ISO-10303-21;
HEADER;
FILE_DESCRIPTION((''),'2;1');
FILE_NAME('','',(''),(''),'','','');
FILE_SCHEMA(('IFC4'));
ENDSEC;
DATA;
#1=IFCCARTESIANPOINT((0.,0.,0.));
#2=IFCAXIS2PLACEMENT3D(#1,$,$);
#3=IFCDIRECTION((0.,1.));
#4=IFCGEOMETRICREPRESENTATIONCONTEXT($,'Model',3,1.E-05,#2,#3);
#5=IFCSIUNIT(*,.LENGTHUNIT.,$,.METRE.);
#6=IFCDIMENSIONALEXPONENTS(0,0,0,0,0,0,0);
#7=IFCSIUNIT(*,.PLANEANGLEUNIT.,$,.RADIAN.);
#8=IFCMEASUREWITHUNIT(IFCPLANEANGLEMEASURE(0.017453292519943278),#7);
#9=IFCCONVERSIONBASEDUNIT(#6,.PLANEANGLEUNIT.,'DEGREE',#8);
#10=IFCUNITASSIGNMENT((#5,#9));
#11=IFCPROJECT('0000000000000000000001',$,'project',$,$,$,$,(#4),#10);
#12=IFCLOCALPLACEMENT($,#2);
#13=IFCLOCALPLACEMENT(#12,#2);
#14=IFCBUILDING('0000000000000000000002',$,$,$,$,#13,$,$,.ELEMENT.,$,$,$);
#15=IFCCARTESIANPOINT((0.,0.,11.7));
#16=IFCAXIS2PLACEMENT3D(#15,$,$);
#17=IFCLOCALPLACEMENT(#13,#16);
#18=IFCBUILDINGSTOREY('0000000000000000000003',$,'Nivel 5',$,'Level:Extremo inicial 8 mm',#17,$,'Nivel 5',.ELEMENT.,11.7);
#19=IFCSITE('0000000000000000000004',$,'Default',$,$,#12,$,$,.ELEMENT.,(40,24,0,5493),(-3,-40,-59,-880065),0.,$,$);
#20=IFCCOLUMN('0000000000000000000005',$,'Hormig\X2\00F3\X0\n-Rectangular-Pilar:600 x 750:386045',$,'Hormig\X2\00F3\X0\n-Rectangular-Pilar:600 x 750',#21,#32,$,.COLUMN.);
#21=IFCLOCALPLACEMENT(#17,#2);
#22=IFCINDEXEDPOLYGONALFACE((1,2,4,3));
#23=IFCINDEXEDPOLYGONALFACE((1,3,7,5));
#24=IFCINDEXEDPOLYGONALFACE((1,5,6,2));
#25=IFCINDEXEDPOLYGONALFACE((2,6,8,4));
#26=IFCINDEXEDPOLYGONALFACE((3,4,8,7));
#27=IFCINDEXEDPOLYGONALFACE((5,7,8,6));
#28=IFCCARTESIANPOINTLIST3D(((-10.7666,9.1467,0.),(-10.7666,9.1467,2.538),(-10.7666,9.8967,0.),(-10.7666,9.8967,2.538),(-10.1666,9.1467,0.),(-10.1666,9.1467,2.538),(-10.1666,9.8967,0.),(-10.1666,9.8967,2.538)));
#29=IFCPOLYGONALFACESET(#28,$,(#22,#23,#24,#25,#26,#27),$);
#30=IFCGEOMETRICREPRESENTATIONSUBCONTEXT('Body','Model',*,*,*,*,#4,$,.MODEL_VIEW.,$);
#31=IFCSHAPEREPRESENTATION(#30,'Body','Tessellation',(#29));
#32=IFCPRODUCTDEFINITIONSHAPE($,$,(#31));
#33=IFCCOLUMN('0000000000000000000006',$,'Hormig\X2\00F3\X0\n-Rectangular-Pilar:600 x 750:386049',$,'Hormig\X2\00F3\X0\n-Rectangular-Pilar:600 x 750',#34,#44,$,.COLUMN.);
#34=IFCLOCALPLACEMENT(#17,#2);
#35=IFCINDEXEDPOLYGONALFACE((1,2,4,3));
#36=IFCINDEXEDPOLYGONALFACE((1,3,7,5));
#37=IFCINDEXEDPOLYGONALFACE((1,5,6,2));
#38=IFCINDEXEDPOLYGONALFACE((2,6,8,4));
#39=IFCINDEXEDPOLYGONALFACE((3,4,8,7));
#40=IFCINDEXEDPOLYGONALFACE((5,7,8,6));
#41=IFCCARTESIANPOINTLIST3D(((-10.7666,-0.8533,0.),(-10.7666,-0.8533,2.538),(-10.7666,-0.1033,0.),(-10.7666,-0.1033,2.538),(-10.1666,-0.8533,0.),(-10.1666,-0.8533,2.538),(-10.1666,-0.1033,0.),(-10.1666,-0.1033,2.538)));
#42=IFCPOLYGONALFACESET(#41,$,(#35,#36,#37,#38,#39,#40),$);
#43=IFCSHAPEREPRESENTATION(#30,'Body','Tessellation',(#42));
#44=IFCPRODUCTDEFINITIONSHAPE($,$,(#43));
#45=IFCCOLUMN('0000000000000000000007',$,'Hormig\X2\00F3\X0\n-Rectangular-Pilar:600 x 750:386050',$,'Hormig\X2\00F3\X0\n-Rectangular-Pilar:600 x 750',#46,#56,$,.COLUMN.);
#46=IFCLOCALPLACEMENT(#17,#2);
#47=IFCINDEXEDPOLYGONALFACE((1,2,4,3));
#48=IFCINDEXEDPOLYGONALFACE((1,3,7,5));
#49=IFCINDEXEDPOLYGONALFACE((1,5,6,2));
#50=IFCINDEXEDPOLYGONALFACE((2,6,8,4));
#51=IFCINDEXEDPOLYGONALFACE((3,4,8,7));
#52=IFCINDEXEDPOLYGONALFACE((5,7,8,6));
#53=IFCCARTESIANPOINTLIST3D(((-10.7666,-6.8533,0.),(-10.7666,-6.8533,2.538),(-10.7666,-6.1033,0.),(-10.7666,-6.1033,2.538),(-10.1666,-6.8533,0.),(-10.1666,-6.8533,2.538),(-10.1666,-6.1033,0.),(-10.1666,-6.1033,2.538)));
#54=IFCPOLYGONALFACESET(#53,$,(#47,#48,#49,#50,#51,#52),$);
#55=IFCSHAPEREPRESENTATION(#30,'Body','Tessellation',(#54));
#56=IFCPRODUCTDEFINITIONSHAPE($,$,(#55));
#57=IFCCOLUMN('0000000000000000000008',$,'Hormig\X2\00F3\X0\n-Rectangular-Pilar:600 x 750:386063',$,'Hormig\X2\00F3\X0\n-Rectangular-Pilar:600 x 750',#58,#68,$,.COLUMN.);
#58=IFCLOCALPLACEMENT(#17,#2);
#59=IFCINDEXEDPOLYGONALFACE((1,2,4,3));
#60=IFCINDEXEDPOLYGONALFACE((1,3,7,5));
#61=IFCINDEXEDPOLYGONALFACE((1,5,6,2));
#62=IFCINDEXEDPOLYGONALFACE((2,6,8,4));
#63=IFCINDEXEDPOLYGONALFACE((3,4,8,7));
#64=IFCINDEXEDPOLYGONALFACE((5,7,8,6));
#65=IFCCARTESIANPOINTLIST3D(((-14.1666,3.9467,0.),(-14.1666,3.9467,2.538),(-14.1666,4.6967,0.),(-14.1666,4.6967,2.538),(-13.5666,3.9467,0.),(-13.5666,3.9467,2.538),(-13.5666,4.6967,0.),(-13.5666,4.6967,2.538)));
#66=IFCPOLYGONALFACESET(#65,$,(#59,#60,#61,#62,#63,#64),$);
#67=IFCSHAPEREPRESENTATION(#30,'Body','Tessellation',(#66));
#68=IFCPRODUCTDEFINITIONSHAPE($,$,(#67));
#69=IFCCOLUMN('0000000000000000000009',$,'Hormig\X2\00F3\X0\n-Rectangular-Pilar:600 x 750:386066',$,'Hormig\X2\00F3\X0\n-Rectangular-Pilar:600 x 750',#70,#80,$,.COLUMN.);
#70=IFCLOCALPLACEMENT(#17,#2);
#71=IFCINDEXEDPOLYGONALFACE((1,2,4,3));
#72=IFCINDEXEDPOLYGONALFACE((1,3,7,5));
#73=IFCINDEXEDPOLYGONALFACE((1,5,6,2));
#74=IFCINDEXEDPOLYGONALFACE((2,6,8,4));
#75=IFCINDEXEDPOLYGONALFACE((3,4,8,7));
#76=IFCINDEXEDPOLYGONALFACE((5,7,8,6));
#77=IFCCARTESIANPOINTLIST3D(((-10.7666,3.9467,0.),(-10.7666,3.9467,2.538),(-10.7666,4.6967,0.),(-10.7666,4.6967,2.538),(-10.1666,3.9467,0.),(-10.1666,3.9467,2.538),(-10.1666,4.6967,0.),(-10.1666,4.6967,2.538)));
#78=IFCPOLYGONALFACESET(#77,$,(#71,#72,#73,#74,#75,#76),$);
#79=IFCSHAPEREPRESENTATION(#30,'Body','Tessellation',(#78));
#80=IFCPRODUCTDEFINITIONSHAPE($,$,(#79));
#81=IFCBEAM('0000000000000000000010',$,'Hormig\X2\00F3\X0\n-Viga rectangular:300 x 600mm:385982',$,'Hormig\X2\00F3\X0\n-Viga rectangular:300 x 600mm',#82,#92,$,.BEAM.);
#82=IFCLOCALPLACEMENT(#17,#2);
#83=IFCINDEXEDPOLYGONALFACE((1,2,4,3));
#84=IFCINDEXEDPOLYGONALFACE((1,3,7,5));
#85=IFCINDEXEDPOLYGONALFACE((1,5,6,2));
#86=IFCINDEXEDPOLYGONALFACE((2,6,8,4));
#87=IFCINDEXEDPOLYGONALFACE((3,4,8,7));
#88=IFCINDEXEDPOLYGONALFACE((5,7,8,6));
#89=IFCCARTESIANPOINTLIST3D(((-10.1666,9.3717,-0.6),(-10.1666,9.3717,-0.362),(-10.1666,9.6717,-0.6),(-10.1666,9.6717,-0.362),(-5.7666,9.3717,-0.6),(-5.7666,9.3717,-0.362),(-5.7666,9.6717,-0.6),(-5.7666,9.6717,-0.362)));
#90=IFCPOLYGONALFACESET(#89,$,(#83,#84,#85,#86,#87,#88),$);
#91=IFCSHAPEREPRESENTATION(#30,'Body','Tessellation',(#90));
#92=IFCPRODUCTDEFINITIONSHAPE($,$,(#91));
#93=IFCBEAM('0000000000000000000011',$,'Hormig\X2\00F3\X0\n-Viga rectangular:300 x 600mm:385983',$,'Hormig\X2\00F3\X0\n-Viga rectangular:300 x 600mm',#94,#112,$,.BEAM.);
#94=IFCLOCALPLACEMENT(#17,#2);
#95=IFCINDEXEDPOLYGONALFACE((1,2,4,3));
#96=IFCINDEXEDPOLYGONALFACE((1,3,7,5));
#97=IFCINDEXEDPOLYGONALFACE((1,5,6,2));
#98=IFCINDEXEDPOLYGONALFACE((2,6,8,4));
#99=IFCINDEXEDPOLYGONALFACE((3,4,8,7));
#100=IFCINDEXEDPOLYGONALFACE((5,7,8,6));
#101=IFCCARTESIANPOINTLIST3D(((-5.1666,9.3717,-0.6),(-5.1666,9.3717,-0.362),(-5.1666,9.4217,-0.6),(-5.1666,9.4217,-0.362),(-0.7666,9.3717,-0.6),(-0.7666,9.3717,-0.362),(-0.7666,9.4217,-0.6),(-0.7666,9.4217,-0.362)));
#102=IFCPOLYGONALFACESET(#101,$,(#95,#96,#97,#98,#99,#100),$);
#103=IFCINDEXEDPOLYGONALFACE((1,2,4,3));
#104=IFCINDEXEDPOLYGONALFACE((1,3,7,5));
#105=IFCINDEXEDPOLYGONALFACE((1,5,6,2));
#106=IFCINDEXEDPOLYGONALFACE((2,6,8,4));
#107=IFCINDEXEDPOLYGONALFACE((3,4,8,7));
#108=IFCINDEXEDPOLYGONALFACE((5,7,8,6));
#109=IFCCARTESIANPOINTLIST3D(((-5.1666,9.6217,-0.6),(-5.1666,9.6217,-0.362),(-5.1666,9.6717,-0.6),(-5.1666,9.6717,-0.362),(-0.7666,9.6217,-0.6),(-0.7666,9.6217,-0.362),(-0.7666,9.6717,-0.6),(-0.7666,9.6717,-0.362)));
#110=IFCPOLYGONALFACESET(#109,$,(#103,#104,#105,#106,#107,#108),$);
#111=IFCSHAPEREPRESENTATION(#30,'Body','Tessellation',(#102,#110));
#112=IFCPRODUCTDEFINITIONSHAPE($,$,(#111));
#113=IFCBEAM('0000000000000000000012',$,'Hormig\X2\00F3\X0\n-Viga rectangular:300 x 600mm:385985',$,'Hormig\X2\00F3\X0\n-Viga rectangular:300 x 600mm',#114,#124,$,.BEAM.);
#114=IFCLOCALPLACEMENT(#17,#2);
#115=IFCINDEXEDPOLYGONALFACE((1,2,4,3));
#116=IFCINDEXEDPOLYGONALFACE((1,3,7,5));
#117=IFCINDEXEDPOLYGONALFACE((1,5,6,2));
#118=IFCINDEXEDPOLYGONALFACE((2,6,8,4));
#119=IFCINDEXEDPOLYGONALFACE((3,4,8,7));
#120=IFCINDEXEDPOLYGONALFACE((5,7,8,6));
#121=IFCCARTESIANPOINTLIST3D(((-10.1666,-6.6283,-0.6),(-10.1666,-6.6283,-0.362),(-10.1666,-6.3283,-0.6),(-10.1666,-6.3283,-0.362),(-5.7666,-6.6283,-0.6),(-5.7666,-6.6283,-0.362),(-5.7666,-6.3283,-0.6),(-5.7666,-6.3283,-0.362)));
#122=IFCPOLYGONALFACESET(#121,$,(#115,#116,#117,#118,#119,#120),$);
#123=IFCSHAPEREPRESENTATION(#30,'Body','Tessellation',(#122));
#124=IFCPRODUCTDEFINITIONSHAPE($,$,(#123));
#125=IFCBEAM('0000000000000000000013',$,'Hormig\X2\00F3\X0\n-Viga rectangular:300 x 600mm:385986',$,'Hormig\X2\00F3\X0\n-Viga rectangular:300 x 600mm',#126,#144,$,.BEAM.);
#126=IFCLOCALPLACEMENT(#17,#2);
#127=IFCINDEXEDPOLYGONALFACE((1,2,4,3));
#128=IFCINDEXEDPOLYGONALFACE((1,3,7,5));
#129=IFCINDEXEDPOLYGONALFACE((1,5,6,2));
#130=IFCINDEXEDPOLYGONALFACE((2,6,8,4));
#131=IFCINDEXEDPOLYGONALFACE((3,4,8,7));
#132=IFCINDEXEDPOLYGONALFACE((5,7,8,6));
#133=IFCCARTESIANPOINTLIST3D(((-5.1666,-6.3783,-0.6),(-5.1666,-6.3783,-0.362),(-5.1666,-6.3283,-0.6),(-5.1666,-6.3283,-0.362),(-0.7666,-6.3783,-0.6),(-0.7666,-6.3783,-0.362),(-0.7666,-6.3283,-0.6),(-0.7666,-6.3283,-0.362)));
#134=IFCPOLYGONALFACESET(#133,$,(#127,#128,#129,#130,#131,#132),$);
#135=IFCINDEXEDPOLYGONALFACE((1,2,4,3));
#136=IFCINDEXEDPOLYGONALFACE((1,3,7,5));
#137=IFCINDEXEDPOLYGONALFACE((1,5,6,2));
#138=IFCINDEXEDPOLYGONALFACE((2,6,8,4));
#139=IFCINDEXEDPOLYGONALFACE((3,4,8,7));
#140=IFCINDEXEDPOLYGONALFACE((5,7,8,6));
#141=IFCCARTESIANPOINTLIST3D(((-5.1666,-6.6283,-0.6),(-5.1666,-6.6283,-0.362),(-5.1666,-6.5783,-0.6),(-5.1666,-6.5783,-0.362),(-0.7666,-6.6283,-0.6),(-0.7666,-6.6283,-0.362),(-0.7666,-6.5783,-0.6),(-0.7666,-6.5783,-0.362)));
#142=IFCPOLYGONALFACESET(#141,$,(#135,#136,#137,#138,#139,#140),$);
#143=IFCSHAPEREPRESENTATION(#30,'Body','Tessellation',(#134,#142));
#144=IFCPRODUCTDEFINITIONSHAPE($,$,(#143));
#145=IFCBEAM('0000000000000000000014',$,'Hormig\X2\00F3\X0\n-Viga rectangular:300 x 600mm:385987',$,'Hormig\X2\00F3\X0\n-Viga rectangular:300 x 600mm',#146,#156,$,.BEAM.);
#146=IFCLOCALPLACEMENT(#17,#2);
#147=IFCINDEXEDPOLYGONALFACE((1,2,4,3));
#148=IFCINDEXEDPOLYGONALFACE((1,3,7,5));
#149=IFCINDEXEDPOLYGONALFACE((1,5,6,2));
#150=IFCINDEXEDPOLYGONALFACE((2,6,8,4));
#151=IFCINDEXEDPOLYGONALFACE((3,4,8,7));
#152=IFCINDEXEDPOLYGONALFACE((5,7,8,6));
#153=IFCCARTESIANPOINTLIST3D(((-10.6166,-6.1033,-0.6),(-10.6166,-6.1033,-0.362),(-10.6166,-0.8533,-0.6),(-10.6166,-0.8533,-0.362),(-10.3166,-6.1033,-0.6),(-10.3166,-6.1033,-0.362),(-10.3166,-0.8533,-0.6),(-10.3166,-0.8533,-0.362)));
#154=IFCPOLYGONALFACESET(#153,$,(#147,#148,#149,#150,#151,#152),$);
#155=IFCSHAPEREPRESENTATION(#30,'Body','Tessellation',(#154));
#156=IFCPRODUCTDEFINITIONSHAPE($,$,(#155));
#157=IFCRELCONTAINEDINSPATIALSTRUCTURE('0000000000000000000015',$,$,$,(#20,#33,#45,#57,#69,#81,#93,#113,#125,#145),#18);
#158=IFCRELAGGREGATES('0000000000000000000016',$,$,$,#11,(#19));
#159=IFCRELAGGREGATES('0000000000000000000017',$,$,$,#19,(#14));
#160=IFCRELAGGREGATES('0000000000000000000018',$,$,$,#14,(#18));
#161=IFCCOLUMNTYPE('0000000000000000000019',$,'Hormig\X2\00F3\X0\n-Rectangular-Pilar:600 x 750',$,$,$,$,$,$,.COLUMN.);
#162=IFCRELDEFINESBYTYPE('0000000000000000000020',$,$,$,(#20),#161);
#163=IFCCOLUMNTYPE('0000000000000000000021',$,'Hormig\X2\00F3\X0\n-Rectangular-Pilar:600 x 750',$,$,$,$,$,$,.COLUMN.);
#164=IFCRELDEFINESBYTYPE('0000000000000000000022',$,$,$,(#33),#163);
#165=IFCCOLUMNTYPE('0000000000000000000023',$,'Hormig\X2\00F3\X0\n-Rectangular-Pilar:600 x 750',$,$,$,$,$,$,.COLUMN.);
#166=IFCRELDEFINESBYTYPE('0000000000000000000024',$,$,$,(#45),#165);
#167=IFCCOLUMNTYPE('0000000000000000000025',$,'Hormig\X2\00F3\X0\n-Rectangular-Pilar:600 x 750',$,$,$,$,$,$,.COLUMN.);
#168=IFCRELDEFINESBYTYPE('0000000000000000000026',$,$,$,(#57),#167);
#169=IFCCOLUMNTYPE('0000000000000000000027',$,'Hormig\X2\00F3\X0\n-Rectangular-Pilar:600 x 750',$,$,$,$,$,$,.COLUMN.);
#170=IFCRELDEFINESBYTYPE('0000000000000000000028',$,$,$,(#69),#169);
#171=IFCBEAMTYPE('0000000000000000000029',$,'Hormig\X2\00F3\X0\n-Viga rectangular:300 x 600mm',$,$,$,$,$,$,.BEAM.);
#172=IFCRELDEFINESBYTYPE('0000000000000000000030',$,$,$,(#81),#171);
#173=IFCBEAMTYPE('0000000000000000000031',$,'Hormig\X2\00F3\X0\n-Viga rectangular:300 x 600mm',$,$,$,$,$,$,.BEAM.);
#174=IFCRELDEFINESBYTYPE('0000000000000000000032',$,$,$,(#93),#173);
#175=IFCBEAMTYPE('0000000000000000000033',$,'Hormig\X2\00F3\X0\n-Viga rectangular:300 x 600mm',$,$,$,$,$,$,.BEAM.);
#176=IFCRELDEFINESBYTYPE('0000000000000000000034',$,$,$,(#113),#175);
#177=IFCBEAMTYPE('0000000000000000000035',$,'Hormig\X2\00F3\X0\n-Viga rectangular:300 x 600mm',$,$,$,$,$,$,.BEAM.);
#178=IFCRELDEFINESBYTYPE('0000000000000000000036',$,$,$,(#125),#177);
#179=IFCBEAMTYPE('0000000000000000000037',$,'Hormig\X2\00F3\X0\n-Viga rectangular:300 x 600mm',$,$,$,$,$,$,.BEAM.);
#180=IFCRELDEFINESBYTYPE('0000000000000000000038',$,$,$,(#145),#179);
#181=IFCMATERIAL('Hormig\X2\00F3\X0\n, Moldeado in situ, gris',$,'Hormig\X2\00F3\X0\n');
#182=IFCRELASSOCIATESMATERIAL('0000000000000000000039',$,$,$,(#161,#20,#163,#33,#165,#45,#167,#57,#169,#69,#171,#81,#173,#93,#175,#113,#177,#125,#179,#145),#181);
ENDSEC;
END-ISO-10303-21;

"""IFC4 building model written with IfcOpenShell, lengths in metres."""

from ifc_helpers import new_model, entity, si_unit, converted_unit, direction, frame, origin, place, context, subcontext, project, spatial, indexed_curve, outline, extrude, source, transform, mapped, material, type_object, type_shapes, element, save


model = new_model("IFC4")

# Units and contexts
model_context = context("Model", 3, precision=1e-05, world=origin(), true_north=direction((0.0, 1.0)))
body_context = subcontext(model_context, "Body", "Model", "MODEL_VIEW")
ifc_project = project(units=[si_unit("LENGTHUNIT", "METRE"), converted_unit("PLANEANGLEUNIT", "DEGREE", entity("IfcPlaneAngleMeasure", 0.017453292519943278), si_unit("PLANEANGLEUNIT", "RADIAN"), dimensions=[0, 0, 0, 0, 0, 0, 0])], contexts=[model_context])

# Site, building, storey
site_placement = place(None, origin())
site = spatial("IfcSite", under=ifc_project, at=site_placement, Name="Default", CompositionType="ELEMENT", RefLatitude=(40, 24, 0, 5493), RefLongitude=(-3, -40, -59, -880065), RefElevation=0.0)
building_placement = place(site_placement, origin())
building = spatial("IfcBuilding", under=site, at=building_placement, CompositionType="ELEMENT")
storey_placement = place(building_placement, frame((0.0, 0.0, 11.7)))
storey = spatial("IfcBuildingStorey", under=building, at=storey_placement, Name="Nivel 5", ObjectType="Level:Extremo inicial 8 mm", LongName="Nivel 5", CompositionType="ELEMENT", Elevation=11.7)

# Columns
ifc_material_1 = material(Name="Hormigón, Moldeado in situ, gris", Category="Hormigón")
column_type_1 = type_object("IfcColumnType", Name="Hormigón-Rectangular-Pilar:600 x 750", PredefinedType="COLUMN", material=ifc_material_1)
shared_shape_1 = source(origin(), body_context, "Body", "SweptSolid", [
    extrude(outline(indexed_curve([(-0.3, -0.375), (0.3, -0.375), (0.3, 0.375), (-0.3, 0.375), (-0.3, -0.375)], self_intersect=False)), frame((-10.4666, 9.5217, 11.7), z_axis=(0.0, 0.0, 1.0), x_axis=(-1.0, 0.0, 0.0)), (0.0, 0.0, 1.0), 2.538),
])
type_shapes(column_type_1, [shared_shape_1])
column_1_placement = place(storey_placement, frame((0.0, 0.0, -11.7)))
element("IfcColumn", 1, at=column_1_placement, inside=storey, type_object=column_type_1, material=ifc_material_1, Name="Hormigón-Rectangular-Pilar:600 x 750:386045", ObjectType="Hormigón-Rectangular-Pilar:600 x 750", PredefinedType="COLUMN", context=body_context, shape_type="MappedRepresentation", body=[
    mapped(shared_shape_1, transform((0.0, 0.0, 0.0), scale=1.0)),
])
column_type_2 = type_object("IfcColumnType", Name="Hormigón-Rectangular-Pilar:600 x 750", PredefinedType="COLUMN", material=ifc_material_1)
shared_shape_2 = source(origin(), body_context, "Body", "SweptSolid", [
    extrude(outline(indexed_curve([(-0.3, -0.375), (0.3, -0.375), (0.3, 0.375), (-0.3, 0.375), (-0.3, -0.375)], self_intersect=False)), frame((-10.4666, -0.4783, 11.7), z_axis=(0.0, 0.0, 1.0), x_axis=(-1.0, 0.0, 0.0)), (0.0, 0.0, 1.0), 2.538),
])
type_shapes(column_type_2, [shared_shape_2])
column_2_placement = place(storey_placement, frame((0.0, 0.0, -11.7)))
element("IfcColumn", 2, at=column_2_placement, inside=storey, type_object=column_type_2, material=ifc_material_1, Name="Hormigón-Rectangular-Pilar:600 x 750:386049", ObjectType="Hormigón-Rectangular-Pilar:600 x 750", PredefinedType="COLUMN", context=body_context, shape_type="MappedRepresentation", body=[
    mapped(shared_shape_2, transform((0.0, 0.0, 0.0), scale=1.0)),
])
column_type_3 = type_object("IfcColumnType", Name="Hormigón-Rectangular-Pilar:600 x 750", PredefinedType="COLUMN", material=ifc_material_1)
shared_shape_3 = source(origin(), body_context, "Body", "SweptSolid", [
    extrude(outline(indexed_curve([(-0.3, -0.375), (0.3, -0.375), (0.3, 0.375), (-0.3, 0.375), (-0.3, -0.375)], self_intersect=False)), frame((-10.4666, -6.4783, 11.7), z_axis=(0.0, 0.0, 1.0), x_axis=(-1.0, 0.0, 0.0)), (0.0, 0.0, 1.0), 2.538),
])
type_shapes(column_type_3, [shared_shape_3])
column_3_placement = place(storey_placement, frame((0.0, 0.0, -11.7)))
element("IfcColumn", 3, at=column_3_placement, inside=storey, type_object=column_type_3, material=ifc_material_1, Name="Hormigón-Rectangular-Pilar:600 x 750:386050", ObjectType="Hormigón-Rectangular-Pilar:600 x 750", PredefinedType="COLUMN", context=body_context, shape_type="MappedRepresentation", body=[
    mapped(shared_shape_3, transform((0.0, 0.0, 0.0), scale=1.0)),
])
column_type_4 = type_object("IfcColumnType", Name="Hormigón-Rectangular-Pilar:600 x 750", PredefinedType="COLUMN", material=ifc_material_1)
shared_shape_4 = source(origin(), body_context, "Body", "SweptSolid", [
    extrude(outline(indexed_curve([(-0.3, -0.375), (0.3, -0.375), (0.3, 0.375), (-0.3, 0.375), (-0.3, -0.375)], self_intersect=False)), frame((-13.8666, 4.3217, 11.7), z_axis=(0.0, 0.0, 1.0), x_axis=(-1.0, 0.0, 0.0)), (0.0, 0.0, 1.0), 2.538),
])
type_shapes(column_type_4, [shared_shape_4])
column_4_placement = place(storey_placement, frame((0.0, 0.0, -11.7)))
element("IfcColumn", 4, at=column_4_placement, inside=storey, type_object=column_type_4, material=ifc_material_1, Name="Hormigón-Rectangular-Pilar:600 x 750:386063", ObjectType="Hormigón-Rectangular-Pilar:600 x 750", PredefinedType="COLUMN", context=body_context, shape_type="MappedRepresentation", body=[
    mapped(shared_shape_4, transform((0.0, 0.0, 0.0), scale=1.0)),
])
column_type_5 = type_object("IfcColumnType", Name="Hormigón-Rectangular-Pilar:600 x 750", PredefinedType="COLUMN", material=ifc_material_1)
shared_shape_5 = source(origin(), body_context, "Body", "SweptSolid", [
    extrude(outline(indexed_curve([(-0.3, -0.375), (0.3, -0.375), (0.3, 0.375), (-0.3, 0.375), (-0.3, -0.375)], self_intersect=False)), frame((-10.4666, 4.3217, 11.7), z_axis=(0.0, 0.0, 1.0), x_axis=(-1.0, 0.0, 0.0)), (0.0, 0.0, 1.0), 2.538),
])
type_shapes(column_type_5, [shared_shape_5])
column_5_placement = place(storey_placement, frame((0.0, 0.0, -11.7)))
element("IfcColumn", 5, at=column_5_placement, inside=storey, type_object=column_type_5, material=ifc_material_1, Name="Hormigón-Rectangular-Pilar:600 x 750:386066", ObjectType="Hormigón-Rectangular-Pilar:600 x 750", PredefinedType="COLUMN", context=body_context, shape_type="MappedRepresentation", body=[
    mapped(shared_shape_5, transform((0.0, 0.0, 0.0), scale=1.0)),
])

# Beams
beam_type_1 = type_object("IfcBeamType", Name="Hormigón-Viga rectangular:300 x 600mm", PredefinedType="BEAM", material=ifc_material_1)
shared_shape_6 = source(origin(), body_context, "Body", "SweptSolid", [
    extrude(outline(indexed_curve([(-0.119, -0.15), (0.119, -0.15), (0.119, 0.15), (-0.119, 0.15), (-0.119, -0.15)], self_intersect=False)), frame((-5.7666, 9.5217, 11.219), z_axis=(-1.0, 0.0, 0.0), x_axis=(0.0, 0.0, -1.0)), (0.0, 0.0, 1.0), 4.4),
])
type_shapes(beam_type_1, [shared_shape_6])
beam_1_placement = place(storey_placement, frame((0.0, 0.0, -11.7)))
element("IfcBeam", 6, at=beam_1_placement, inside=storey, type_object=beam_type_1, material=ifc_material_1, Name="Hormigón-Viga rectangular:300 x 600mm:385982", ObjectType="Hormigón-Viga rectangular:300 x 600mm", PredefinedType="BEAM", context=body_context, shape_type="MappedRepresentation", body=[
    mapped(shared_shape_6, transform((0.0, 0.0, 0.0), scale=1.0)),
])
beam_type_2 = type_object("IfcBeamType", Name="Hormigón-Viga rectangular:300 x 600mm", PredefinedType="BEAM", material=ifc_material_1)
shared_shape_7 = source(origin(), body_context, "Body", "SweptSolid", [
    extrude(outline(indexed_curve([(-0.119, -0.025), (0.119, -0.025), (0.119, 0.025), (-0.119, 0.025), (-0.119, -0.025)], self_intersect=False)), frame((-5.1666, 9.3967, 11.219), z_axis=(1.0, 0.0, 0.0), x_axis=(0.0, 0.0, -1.0)), (0.0, 0.0, 1.0), 4.4),
    extrude(outline(indexed_curve([(-0.119, -0.025), (0.119, -0.025), (0.119, 0.025), (-0.119, 0.025), (-0.119, -0.025)], self_intersect=False)), frame((-5.1666, 9.6467, 11.219), z_axis=(1.0, 0.0, 0.0), x_axis=(0.0, 0.0, -1.0)), (0.0, 0.0, 1.0), 4.4),
])
type_shapes(beam_type_2, [shared_shape_7])
beam_2_placement = place(storey_placement, frame((0.0, 0.0, -11.7)))
element("IfcBeam", 7, at=beam_2_placement, inside=storey, type_object=beam_type_2, material=ifc_material_1, Name="Hormigón-Viga rectangular:300 x 600mm:385983", ObjectType="Hormigón-Viga rectangular:300 x 600mm", PredefinedType="BEAM", context=body_context, shape_type="MappedRepresentation", body=[
    mapped(shared_shape_7, transform((0.0, 0.0, 0.0), scale=1.0)),
])
beam_type_3 = type_object("IfcBeamType", Name="Hormigón-Viga rectangular:300 x 600mm", PredefinedType="BEAM", material=ifc_material_1)
shared_shape_8 = source(origin(), body_context, "Body", "SweptSolid", [
    extrude(outline(indexed_curve([(-0.119, -0.15), (0.119, -0.15), (0.119, 0.15), (-0.119, 0.15), (-0.119, -0.15)], self_intersect=False)), frame((-10.1666, -6.4783, 11.219), z_axis=(1.0, 0.0, 0.0), x_axis=(0.0, 0.0, -1.0)), (0.0, 0.0, 1.0), 4.4),
])
type_shapes(beam_type_3, [shared_shape_8])
beam_3_placement = place(storey_placement, frame((0.0, 0.0, -11.7)))
element("IfcBeam", 8, at=beam_3_placement, inside=storey, type_object=beam_type_3, material=ifc_material_1, Name="Hormigón-Viga rectangular:300 x 600mm:385985", ObjectType="Hormigón-Viga rectangular:300 x 600mm", PredefinedType="BEAM", context=body_context, shape_type="MappedRepresentation", body=[
    mapped(shared_shape_8, transform((0.0, 0.0, 0.0), scale=1.0)),
])
beam_type_4 = type_object("IfcBeamType", Name="Hormigón-Viga rectangular:300 x 600mm", PredefinedType="BEAM", material=ifc_material_1)
shared_shape_9 = source(origin(), body_context, "Body", "SweptSolid", [
    extrude(outline(indexed_curve([(-0.119, -0.025), (0.119, -0.025), (0.119, 0.025), (-0.119, 0.025), (-0.119, -0.025)], self_intersect=False)), frame((-0.7666, -6.3533, 11.219), z_axis=(-1.0, 0.0, 0.0), x_axis=(0.0, 0.0, -1.0)), (0.0, 0.0, 1.0), 4.4),
    extrude(outline(indexed_curve([(-0.119, -0.025), (0.119, -0.025), (0.119, 0.025), (-0.119, 0.025), (-0.119, -0.025)], self_intersect=False)), frame((-0.7666, -6.6033, 11.219), z_axis=(-1.0, 0.0, 0.0), x_axis=(0.0, 0.0, -1.0)), (0.0, 0.0, 1.0), 4.4),
])
type_shapes(beam_type_4, [shared_shape_9])
beam_4_placement = place(storey_placement, frame((0.0, 0.0, -11.7)))
element("IfcBeam", 9, at=beam_4_placement, inside=storey, type_object=beam_type_4, material=ifc_material_1, Name="Hormigón-Viga rectangular:300 x 600mm:385986", ObjectType="Hormigón-Viga rectangular:300 x 600mm", PredefinedType="BEAM", context=body_context, shape_type="MappedRepresentation", body=[
    mapped(shared_shape_9, transform((0.0, 0.0, 0.0), scale=1.0)),
])
beam_type_5 = type_object("IfcBeamType", Name="Hormigón-Viga rectangular:300 x 600mm", PredefinedType="BEAM", material=ifc_material_1)
shared_shape_10 = source(origin(), body_context, "Body", "SweptSolid", [
    extrude(outline(indexed_curve([(-0.15, -0.119), (0.15, -0.119), (0.15, 0.119), (-0.15, 0.119), (-0.15, -0.119)], self_intersect=False)), frame((-10.4666, -6.1033, 11.219), z_axis=(0.0, 1.0, 0.0), x_axis=(-1.0, 0.0, 0.0)), (0.0, 0.0, 1.0), 5.25),
])
type_shapes(beam_type_5, [shared_shape_10])
beam_5_placement = place(storey_placement, frame((0.0, 0.0, -11.7)))
element("IfcBeam", 10, at=beam_5_placement, inside=storey, type_object=beam_type_5, material=ifc_material_1, Name="Hormigón-Viga rectangular:300 x 600mm:385987", ObjectType="Hormigón-Viga rectangular:300 x 600mm", PredefinedType="BEAM", context=body_context, shape_type="MappedRepresentation", body=[
    mapped(shared_shape_10, transform((0.0, 0.0, 0.0), scale=1.0)),
])

save(model, "model.ifc")
